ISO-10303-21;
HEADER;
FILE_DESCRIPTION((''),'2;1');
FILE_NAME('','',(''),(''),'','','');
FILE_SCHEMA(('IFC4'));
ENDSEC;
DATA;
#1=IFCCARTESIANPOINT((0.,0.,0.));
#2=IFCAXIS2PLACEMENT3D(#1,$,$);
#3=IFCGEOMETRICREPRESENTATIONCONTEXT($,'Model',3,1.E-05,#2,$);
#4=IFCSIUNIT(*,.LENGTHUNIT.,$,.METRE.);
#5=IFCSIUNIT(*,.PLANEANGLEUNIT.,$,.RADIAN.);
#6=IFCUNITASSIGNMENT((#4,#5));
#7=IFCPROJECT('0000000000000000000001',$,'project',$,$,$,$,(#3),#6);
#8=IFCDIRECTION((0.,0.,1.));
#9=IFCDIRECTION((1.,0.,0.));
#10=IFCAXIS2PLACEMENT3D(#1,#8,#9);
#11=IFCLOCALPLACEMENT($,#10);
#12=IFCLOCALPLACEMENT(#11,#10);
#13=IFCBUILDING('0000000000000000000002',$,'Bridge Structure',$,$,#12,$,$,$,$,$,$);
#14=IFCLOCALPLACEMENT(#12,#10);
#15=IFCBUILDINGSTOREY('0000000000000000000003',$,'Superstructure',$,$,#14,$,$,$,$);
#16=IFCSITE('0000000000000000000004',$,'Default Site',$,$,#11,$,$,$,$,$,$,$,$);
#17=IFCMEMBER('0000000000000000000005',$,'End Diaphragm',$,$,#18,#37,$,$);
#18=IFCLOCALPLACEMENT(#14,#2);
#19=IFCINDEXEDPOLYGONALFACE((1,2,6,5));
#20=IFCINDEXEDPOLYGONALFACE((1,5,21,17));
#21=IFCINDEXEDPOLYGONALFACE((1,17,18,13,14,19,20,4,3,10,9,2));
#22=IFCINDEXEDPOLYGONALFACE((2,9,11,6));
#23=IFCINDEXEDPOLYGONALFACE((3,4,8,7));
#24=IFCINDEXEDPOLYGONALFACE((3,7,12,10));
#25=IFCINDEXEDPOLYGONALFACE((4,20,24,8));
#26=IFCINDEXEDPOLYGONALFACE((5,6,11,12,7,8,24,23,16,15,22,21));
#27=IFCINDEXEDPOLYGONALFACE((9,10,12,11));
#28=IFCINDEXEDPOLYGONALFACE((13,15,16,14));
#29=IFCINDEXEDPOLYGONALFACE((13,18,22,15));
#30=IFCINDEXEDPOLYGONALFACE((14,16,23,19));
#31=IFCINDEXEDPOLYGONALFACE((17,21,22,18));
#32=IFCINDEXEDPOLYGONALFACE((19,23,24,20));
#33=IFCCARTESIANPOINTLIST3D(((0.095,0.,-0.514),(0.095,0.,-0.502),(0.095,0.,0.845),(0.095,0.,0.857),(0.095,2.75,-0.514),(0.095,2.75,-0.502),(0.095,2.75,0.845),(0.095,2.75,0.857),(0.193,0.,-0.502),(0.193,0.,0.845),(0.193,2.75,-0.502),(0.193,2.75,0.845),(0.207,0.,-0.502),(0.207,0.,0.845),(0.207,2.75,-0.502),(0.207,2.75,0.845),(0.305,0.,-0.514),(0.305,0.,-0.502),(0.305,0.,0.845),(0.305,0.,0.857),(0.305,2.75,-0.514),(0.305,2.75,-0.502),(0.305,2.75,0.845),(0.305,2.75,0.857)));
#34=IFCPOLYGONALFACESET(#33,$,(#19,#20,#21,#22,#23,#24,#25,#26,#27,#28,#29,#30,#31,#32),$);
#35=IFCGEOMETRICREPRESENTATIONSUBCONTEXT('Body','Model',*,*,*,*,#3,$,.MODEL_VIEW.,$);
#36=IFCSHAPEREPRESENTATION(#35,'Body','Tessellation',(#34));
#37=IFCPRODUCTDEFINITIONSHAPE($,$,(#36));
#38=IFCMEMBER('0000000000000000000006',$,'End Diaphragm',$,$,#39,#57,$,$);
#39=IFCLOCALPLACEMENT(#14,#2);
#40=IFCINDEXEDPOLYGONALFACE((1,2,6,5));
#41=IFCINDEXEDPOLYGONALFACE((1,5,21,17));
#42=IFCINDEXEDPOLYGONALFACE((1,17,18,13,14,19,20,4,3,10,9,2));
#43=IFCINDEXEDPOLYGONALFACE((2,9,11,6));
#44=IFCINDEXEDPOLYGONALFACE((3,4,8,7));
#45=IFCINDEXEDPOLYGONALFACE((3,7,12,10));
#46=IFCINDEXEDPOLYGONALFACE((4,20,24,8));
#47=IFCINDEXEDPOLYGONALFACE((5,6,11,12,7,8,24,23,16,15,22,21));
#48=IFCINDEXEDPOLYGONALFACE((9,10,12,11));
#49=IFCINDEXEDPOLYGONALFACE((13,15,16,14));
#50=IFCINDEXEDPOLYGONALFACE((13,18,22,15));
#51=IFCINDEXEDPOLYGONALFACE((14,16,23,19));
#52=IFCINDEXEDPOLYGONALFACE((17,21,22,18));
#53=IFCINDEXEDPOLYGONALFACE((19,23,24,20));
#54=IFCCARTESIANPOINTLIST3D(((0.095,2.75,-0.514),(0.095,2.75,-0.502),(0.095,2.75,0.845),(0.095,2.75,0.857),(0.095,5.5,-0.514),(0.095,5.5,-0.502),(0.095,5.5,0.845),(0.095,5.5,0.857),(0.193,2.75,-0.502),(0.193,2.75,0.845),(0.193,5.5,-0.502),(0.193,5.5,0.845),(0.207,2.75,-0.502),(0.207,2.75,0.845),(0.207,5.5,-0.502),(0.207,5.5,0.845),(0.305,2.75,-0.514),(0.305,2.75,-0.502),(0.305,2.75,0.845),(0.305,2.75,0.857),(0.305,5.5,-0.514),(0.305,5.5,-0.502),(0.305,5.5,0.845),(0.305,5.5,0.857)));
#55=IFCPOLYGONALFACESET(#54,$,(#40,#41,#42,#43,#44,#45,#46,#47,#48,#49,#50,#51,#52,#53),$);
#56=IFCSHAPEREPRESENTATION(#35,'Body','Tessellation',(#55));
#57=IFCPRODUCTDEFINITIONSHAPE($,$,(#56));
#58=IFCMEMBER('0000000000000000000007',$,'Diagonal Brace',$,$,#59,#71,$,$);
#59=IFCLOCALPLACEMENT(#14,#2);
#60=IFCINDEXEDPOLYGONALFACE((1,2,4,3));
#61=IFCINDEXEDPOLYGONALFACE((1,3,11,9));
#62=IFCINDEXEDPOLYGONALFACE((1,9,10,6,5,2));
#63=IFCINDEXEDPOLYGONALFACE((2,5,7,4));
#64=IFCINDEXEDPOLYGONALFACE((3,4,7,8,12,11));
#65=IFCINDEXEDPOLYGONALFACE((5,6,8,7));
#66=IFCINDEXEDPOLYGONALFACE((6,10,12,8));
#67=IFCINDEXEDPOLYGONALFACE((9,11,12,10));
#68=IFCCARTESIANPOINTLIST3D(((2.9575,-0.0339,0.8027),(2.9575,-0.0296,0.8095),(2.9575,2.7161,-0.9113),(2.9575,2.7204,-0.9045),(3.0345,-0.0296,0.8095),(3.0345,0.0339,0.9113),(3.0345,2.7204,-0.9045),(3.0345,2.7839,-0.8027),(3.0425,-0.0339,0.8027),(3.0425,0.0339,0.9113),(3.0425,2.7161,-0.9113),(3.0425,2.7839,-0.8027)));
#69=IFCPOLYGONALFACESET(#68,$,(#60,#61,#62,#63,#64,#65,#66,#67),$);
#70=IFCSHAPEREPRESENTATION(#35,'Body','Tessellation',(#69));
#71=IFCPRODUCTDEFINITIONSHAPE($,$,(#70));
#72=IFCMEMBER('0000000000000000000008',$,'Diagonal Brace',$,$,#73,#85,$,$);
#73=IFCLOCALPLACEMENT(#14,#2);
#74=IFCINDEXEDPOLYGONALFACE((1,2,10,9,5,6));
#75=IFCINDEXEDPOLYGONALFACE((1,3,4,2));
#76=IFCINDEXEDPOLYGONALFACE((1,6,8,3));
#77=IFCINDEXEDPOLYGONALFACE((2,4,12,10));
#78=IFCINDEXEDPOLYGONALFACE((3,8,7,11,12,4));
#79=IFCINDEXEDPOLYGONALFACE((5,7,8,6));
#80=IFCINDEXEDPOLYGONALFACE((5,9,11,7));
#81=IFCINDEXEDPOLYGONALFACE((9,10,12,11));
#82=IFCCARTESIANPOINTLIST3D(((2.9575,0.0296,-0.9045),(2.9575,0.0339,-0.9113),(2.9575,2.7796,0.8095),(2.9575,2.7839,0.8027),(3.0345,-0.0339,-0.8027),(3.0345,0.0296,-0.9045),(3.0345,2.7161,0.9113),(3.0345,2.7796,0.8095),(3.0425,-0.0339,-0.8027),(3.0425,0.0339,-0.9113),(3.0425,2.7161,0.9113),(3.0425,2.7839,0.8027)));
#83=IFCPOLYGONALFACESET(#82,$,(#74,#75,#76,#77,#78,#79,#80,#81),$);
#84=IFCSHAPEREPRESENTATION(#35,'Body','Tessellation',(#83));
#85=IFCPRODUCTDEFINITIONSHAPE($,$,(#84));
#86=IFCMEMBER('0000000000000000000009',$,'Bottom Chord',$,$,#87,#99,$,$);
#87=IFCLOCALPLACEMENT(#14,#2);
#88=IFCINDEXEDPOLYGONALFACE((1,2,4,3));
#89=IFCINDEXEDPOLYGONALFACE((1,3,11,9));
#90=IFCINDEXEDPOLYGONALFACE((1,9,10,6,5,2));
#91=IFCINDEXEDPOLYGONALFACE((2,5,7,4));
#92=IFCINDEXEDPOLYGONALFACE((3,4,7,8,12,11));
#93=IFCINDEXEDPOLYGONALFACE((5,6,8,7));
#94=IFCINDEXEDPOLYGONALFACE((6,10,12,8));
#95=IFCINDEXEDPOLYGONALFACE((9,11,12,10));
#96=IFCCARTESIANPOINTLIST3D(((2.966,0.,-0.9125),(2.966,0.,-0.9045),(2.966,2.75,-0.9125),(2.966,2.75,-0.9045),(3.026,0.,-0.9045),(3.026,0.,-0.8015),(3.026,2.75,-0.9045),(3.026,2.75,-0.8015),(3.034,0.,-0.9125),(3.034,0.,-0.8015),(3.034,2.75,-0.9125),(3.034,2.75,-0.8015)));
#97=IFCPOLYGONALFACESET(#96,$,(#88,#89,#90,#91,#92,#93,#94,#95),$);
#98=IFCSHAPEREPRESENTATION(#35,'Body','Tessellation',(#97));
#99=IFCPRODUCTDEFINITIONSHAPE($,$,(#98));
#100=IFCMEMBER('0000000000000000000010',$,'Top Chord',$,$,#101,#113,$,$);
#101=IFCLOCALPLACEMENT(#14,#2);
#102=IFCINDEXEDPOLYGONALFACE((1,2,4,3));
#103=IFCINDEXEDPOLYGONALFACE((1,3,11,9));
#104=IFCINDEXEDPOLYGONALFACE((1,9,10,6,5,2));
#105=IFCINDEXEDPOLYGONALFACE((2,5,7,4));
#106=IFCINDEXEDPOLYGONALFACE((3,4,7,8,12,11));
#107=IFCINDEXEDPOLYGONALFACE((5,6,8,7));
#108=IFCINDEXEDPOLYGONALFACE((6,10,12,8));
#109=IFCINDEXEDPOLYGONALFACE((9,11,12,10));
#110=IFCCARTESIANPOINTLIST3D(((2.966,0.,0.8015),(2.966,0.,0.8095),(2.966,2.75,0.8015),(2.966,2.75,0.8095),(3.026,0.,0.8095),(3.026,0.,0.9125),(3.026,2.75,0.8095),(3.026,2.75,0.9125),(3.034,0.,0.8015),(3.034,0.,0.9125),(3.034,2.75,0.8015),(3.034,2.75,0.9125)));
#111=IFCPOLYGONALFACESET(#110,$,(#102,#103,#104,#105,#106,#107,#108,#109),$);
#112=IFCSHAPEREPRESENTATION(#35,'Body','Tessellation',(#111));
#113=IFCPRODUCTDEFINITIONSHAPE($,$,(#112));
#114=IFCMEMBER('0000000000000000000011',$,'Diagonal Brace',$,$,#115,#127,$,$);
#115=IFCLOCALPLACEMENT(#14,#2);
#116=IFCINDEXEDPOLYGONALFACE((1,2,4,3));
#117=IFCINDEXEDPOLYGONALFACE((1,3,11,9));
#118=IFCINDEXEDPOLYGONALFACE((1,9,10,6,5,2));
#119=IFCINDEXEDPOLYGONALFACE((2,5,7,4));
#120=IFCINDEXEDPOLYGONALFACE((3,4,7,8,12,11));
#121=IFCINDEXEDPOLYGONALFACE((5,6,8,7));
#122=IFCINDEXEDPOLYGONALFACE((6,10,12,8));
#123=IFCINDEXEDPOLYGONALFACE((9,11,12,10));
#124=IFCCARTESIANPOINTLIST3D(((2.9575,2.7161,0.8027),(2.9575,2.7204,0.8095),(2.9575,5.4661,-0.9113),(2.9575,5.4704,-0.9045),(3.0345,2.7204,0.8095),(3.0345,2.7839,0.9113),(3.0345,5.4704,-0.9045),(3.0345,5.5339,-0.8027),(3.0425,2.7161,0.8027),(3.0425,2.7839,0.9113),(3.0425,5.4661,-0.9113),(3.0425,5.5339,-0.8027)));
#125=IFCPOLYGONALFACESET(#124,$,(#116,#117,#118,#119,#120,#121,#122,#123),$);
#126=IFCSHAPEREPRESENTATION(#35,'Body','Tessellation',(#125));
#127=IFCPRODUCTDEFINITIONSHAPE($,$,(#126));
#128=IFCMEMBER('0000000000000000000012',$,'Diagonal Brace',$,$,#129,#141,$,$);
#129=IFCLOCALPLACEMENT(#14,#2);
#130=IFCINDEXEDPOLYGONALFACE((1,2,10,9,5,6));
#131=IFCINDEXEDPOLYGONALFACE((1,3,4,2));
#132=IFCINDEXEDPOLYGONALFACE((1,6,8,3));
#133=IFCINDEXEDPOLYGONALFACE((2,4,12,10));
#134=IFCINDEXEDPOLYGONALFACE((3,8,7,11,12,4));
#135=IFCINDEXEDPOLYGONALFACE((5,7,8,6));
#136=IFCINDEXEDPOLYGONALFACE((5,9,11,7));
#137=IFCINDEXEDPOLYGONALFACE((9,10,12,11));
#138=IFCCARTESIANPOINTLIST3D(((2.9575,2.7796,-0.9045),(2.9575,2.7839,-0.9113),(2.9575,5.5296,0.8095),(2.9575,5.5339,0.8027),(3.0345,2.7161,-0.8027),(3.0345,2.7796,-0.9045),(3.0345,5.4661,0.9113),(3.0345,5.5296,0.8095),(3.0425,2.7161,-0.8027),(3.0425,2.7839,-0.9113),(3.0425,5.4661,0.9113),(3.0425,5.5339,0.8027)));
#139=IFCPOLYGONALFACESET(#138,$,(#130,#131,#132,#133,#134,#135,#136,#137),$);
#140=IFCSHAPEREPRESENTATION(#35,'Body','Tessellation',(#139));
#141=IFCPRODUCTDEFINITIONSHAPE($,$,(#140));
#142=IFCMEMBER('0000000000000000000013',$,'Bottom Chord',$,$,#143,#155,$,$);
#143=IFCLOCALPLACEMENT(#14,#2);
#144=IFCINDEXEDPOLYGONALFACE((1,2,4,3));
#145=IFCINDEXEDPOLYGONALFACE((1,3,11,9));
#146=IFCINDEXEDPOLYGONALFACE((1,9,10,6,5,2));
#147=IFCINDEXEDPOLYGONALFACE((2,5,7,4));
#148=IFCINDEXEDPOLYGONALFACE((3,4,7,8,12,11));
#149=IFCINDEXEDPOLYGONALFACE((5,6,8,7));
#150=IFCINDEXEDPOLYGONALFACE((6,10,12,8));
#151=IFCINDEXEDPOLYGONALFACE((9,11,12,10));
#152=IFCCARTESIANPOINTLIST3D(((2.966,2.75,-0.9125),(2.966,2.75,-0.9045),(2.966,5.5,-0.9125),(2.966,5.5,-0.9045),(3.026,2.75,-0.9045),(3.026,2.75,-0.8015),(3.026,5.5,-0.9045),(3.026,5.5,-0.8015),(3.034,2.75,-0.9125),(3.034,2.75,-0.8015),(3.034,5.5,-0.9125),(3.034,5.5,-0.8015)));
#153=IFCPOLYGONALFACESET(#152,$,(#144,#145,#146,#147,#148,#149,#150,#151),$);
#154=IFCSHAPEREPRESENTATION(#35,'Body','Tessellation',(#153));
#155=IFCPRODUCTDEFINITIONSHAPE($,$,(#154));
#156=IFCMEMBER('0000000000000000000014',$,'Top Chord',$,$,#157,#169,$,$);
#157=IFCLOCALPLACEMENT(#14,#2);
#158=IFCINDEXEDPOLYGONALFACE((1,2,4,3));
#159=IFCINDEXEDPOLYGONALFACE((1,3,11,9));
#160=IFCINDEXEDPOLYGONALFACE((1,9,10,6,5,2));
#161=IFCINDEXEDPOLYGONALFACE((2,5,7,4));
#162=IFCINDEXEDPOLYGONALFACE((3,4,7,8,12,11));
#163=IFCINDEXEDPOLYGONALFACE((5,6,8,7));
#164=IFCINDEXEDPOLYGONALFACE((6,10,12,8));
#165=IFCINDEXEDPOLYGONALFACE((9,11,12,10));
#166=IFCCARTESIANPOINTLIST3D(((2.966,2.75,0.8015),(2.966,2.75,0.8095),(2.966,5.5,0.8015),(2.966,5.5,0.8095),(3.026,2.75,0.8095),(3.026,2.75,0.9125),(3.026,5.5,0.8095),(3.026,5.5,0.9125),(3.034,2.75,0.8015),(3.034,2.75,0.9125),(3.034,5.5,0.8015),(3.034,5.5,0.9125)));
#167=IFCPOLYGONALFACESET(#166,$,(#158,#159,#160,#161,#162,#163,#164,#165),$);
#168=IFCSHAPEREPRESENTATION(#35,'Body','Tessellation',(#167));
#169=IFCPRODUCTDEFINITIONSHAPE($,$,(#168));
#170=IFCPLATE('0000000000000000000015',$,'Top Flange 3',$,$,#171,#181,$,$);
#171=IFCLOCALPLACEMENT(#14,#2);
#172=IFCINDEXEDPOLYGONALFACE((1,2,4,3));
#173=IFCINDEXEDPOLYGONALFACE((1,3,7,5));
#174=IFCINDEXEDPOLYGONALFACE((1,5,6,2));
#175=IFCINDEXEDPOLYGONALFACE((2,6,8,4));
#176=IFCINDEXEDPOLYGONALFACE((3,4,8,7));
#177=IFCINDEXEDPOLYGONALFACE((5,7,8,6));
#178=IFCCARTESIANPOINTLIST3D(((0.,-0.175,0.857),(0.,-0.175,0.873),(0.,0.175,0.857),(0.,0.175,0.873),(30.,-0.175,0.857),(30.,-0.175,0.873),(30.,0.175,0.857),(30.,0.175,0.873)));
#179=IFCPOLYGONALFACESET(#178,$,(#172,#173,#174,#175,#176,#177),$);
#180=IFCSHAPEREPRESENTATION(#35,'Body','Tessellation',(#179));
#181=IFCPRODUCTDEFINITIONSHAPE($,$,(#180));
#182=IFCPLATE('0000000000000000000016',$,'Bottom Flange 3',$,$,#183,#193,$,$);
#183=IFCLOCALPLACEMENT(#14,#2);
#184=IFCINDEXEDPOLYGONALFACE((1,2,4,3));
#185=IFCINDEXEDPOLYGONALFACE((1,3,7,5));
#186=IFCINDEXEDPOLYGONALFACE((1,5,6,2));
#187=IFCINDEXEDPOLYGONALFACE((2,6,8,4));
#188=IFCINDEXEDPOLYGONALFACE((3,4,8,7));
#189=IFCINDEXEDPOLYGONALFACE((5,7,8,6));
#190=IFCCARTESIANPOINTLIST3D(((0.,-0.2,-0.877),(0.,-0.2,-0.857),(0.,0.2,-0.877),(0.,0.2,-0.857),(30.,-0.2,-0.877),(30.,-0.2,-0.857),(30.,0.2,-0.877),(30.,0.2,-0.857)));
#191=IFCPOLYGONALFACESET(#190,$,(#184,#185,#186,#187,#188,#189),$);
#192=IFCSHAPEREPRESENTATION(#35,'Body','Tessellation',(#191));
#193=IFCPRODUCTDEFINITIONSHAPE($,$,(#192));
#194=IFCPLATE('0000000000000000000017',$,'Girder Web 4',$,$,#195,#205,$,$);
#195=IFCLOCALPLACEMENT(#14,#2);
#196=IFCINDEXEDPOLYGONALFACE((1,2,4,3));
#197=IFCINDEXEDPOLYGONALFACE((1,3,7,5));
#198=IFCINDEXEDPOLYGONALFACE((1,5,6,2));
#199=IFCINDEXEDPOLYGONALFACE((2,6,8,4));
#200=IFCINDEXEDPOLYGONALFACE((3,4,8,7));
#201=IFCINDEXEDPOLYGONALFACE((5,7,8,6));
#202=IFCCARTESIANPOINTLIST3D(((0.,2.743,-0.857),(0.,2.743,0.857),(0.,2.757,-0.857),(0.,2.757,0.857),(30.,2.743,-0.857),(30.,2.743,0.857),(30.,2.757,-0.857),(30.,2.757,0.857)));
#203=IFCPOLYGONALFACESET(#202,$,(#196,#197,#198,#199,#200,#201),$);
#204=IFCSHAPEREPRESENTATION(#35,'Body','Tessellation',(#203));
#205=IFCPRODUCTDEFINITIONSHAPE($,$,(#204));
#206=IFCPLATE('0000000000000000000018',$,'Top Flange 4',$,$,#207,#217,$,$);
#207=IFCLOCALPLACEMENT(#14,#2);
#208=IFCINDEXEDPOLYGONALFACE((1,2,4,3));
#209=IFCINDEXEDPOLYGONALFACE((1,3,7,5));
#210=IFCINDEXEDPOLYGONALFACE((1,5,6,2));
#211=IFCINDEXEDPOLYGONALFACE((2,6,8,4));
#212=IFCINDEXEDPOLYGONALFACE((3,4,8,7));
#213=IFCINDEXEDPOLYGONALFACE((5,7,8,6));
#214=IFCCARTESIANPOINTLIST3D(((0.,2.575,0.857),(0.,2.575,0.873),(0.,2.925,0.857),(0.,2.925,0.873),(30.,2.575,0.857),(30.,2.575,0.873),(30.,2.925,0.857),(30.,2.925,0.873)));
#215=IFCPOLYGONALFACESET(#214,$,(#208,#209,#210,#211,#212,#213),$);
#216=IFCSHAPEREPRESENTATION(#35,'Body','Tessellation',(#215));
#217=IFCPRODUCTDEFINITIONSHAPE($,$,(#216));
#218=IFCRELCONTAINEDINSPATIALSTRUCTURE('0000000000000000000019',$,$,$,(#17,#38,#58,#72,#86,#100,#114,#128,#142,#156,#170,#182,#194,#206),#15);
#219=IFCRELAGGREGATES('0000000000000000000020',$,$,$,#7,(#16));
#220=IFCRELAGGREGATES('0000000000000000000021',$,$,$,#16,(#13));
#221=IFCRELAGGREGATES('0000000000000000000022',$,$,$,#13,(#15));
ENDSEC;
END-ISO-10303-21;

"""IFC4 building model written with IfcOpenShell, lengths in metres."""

from ifc_helpers import new_model, si_unit, frame, origin, origin_with_axes, origin_2d_with_axis, place, context, subcontext, project, spatial, rectangle, i_section, l_section, extrude, element, save


model = new_model("IFC4")

# Units and contexts
model_context = context("Model", 3, precision=1e-05, world=origin())
body_context = subcontext(model_context, "Body", "Model", "MODEL_VIEW")
ifc_project = project(units=[si_unit("LENGTHUNIT", "METRE"), si_unit("PLANEANGLEUNIT", "RADIAN")], contexts=[model_context])

# Site, building, storey
site_placement = place(None, origin_with_axes())
site = spatial("IfcSite", under=ifc_project, at=site_placement, Name="Default Site")
building_placement = place(site_placement, origin_with_axes())
building = spatial("IfcBuilding", under=site, at=building_placement, Name="Bridge Structure")
storey_placement = place(building_placement, origin_with_axes())
storey = spatial("IfcBuildingStorey", under=building, at=storey_placement, Name="Superstructure")

# Members
for number, where, z_axis, x_axis, name in (
    (1, (0.2, 0.0, 0.1715), (0.0, 1.0, 0.0), (-1.0, 0.0, 0.0), "End Diaphragm"),
    (2, (0.2, 2.75, 0.1715), (0.0, 1.0, 0.0), (-1.0, 0.0, 0.0), "End Diaphragm"),
):
    element("IfcMember", number, at=place(storey_placement, frame(where, z_axis=z_axis, x_axis=x_axis)), inside=storey, Name=name, context=body_context, shape_type="SweptSolid", body=[
        extrude(i_section(OverallWidth=0.21, OverallDepth=1.371, WebThickness=0.014, FlangeThickness=0.012, at=origin_2d_with_axis()), origin_with_axes(), (0.0, 0.0, 1.0), 2.75),
    ])
for number, where, z_axis, x_axis, name in (
    (3, (3.0, 0.0, 0.857), (0.0, 0.848656, -0.528944), (-1.0, 0.0, 0.0), "Diagonal Brace"),
    (4, (3.0, 0.0, -0.857), (0.0, 0.848656, 0.528944), (-1.0, 0.0, 0.0), "Diagonal Brace"),
):
    element("IfcMember", number, at=place(storey_placement, frame(where, z_axis=z_axis, x_axis=x_axis)), inside=storey, Name=name, context=body_context, shape_type="SweptSolid", body=[
        extrude(l_section(Depth=0.128, Width=0.085, Thickness=0.008, at=origin_2d_with_axis()), origin_with_axes(), (0.0, 0.0, 1.0), 3.2404),
    ])
for number, where, z_axis, x_axis, name in (
    (5, (3.0, 0.0, -0.857), (0.0, 1.0, 0.0), (-1.0, 0.0, 0.0), "Bottom Chord"),
    (6, (3.0, 0.0, 0.857), (0.0, 1.0, 0.0), (-1.0, 0.0, 0.0), "Top Chord"),
):
    element("IfcMember", number, at=place(storey_placement, frame(where, z_axis=z_axis, x_axis=x_axis)), inside=storey, Name=name, context=body_context, shape_type="SweptSolid", body=[
        extrude(l_section(Depth=0.111, Width=0.068, Thickness=0.008, at=origin_2d_with_axis()), origin_with_axes(), (0.0, 0.0, 1.0), 2.75),
    ])
for number, where, z_axis, x_axis, name in (
    (7, (3.0, 2.75, 0.857), (0.0, 0.848656, -0.528944), (-1.0, 0.0, 0.0), "Diagonal Brace"),
    (8, (3.0, 2.75, -0.857), (0.0, 0.848656, 0.528944), (-1.0, 0.0, 0.0), "Diagonal Brace"),
):
    element("IfcMember", number, at=place(storey_placement, frame(where, z_axis=z_axis, x_axis=x_axis)), inside=storey, Name=name, context=body_context, shape_type="SweptSolid", body=[
        extrude(l_section(Depth=0.128, Width=0.085, Thickness=0.008, at=origin_2d_with_axis()), origin_with_axes(), (0.0, 0.0, 1.0), 3.2404),
    ])
for number, where, z_axis, x_axis, name in (
    (9, (3.0, 2.75, -0.857), (0.0, 1.0, 0.0), (-1.0, 0.0, 0.0), "Bottom Chord"),
    (10, (3.0, 2.75, 0.857), (0.0, 1.0, 0.0), (-1.0, 0.0, 0.0), "Top Chord"),
):
    element("IfcMember", number, at=place(storey_placement, frame(where, z_axis=z_axis, x_axis=x_axis)), inside=storey, Name=name, context=body_context, shape_type="SweptSolid", body=[
        extrude(l_section(Depth=0.111, Width=0.068, Thickness=0.008, at=origin_2d_with_axis()), origin_with_axes(), (0.0, 0.0, 1.0), 2.75),
    ])

# Plates
plate_1_placement = place(storey_placement, frame((0.0, 0.0, 0.865), z_axis=(1.0, 0.0, 0.0), x_axis=(0.0, 1.0, 0.0)))
element("IfcPlate", 11, at=plate_1_placement, inside=storey, Name="Top Flange 3", context=body_context, shape_type="SweptSolid", body=[
    extrude(rectangle(XDim=0.35, YDim=0.016, at=origin_2d_with_axis()), origin_with_axes(), (0.0, 0.0, 1.0), 30.0),
])
plate_2_placement = place(storey_placement, frame((0.0, 0.0, -0.867), z_axis=(1.0, 0.0, 0.0), x_axis=(0.0, 1.0, 0.0)))
element("IfcPlate", 12, at=plate_2_placement, inside=storey, Name="Bottom Flange 3", context=body_context, shape_type="SweptSolid", body=[
    extrude(rectangle(XDim=0.4, YDim=0.02, at=origin_2d_with_axis()), origin_with_axes(), (0.0, 0.0, 1.0), 30.0),
])
plate_3_placement = place(storey_placement, frame((0.0, 2.75, 0.0), z_axis=(1.0, 0.0, 0.0), x_axis=(0.0, 1.0, 0.0)))
element("IfcPlate", 13, at=plate_3_placement, inside=storey, Name="Girder Web 4", context=body_context, shape_type="SweptSolid", body=[
    extrude(rectangle(XDim=0.014, YDim=1.714, at=origin_2d_with_axis()), origin_with_axes(), (0.0, 0.0, 1.0), 30.0),
])
plate_4_placement = place(storey_placement, frame((0.0, 2.75, 0.865), z_axis=(1.0, 0.0, 0.0), x_axis=(0.0, 1.0, 0.0)))
element("IfcPlate", 14, at=plate_4_placement, inside=storey, Name="Top Flange 4", context=body_context, shape_type="SweptSolid", body=[
    extrude(rectangle(XDim=0.35, YDim=0.016, at=origin_2d_with_axis()), origin_with_axes(), (0.0, 0.0, 1.0), 30.0),
])

save(model, "model.ifc")
